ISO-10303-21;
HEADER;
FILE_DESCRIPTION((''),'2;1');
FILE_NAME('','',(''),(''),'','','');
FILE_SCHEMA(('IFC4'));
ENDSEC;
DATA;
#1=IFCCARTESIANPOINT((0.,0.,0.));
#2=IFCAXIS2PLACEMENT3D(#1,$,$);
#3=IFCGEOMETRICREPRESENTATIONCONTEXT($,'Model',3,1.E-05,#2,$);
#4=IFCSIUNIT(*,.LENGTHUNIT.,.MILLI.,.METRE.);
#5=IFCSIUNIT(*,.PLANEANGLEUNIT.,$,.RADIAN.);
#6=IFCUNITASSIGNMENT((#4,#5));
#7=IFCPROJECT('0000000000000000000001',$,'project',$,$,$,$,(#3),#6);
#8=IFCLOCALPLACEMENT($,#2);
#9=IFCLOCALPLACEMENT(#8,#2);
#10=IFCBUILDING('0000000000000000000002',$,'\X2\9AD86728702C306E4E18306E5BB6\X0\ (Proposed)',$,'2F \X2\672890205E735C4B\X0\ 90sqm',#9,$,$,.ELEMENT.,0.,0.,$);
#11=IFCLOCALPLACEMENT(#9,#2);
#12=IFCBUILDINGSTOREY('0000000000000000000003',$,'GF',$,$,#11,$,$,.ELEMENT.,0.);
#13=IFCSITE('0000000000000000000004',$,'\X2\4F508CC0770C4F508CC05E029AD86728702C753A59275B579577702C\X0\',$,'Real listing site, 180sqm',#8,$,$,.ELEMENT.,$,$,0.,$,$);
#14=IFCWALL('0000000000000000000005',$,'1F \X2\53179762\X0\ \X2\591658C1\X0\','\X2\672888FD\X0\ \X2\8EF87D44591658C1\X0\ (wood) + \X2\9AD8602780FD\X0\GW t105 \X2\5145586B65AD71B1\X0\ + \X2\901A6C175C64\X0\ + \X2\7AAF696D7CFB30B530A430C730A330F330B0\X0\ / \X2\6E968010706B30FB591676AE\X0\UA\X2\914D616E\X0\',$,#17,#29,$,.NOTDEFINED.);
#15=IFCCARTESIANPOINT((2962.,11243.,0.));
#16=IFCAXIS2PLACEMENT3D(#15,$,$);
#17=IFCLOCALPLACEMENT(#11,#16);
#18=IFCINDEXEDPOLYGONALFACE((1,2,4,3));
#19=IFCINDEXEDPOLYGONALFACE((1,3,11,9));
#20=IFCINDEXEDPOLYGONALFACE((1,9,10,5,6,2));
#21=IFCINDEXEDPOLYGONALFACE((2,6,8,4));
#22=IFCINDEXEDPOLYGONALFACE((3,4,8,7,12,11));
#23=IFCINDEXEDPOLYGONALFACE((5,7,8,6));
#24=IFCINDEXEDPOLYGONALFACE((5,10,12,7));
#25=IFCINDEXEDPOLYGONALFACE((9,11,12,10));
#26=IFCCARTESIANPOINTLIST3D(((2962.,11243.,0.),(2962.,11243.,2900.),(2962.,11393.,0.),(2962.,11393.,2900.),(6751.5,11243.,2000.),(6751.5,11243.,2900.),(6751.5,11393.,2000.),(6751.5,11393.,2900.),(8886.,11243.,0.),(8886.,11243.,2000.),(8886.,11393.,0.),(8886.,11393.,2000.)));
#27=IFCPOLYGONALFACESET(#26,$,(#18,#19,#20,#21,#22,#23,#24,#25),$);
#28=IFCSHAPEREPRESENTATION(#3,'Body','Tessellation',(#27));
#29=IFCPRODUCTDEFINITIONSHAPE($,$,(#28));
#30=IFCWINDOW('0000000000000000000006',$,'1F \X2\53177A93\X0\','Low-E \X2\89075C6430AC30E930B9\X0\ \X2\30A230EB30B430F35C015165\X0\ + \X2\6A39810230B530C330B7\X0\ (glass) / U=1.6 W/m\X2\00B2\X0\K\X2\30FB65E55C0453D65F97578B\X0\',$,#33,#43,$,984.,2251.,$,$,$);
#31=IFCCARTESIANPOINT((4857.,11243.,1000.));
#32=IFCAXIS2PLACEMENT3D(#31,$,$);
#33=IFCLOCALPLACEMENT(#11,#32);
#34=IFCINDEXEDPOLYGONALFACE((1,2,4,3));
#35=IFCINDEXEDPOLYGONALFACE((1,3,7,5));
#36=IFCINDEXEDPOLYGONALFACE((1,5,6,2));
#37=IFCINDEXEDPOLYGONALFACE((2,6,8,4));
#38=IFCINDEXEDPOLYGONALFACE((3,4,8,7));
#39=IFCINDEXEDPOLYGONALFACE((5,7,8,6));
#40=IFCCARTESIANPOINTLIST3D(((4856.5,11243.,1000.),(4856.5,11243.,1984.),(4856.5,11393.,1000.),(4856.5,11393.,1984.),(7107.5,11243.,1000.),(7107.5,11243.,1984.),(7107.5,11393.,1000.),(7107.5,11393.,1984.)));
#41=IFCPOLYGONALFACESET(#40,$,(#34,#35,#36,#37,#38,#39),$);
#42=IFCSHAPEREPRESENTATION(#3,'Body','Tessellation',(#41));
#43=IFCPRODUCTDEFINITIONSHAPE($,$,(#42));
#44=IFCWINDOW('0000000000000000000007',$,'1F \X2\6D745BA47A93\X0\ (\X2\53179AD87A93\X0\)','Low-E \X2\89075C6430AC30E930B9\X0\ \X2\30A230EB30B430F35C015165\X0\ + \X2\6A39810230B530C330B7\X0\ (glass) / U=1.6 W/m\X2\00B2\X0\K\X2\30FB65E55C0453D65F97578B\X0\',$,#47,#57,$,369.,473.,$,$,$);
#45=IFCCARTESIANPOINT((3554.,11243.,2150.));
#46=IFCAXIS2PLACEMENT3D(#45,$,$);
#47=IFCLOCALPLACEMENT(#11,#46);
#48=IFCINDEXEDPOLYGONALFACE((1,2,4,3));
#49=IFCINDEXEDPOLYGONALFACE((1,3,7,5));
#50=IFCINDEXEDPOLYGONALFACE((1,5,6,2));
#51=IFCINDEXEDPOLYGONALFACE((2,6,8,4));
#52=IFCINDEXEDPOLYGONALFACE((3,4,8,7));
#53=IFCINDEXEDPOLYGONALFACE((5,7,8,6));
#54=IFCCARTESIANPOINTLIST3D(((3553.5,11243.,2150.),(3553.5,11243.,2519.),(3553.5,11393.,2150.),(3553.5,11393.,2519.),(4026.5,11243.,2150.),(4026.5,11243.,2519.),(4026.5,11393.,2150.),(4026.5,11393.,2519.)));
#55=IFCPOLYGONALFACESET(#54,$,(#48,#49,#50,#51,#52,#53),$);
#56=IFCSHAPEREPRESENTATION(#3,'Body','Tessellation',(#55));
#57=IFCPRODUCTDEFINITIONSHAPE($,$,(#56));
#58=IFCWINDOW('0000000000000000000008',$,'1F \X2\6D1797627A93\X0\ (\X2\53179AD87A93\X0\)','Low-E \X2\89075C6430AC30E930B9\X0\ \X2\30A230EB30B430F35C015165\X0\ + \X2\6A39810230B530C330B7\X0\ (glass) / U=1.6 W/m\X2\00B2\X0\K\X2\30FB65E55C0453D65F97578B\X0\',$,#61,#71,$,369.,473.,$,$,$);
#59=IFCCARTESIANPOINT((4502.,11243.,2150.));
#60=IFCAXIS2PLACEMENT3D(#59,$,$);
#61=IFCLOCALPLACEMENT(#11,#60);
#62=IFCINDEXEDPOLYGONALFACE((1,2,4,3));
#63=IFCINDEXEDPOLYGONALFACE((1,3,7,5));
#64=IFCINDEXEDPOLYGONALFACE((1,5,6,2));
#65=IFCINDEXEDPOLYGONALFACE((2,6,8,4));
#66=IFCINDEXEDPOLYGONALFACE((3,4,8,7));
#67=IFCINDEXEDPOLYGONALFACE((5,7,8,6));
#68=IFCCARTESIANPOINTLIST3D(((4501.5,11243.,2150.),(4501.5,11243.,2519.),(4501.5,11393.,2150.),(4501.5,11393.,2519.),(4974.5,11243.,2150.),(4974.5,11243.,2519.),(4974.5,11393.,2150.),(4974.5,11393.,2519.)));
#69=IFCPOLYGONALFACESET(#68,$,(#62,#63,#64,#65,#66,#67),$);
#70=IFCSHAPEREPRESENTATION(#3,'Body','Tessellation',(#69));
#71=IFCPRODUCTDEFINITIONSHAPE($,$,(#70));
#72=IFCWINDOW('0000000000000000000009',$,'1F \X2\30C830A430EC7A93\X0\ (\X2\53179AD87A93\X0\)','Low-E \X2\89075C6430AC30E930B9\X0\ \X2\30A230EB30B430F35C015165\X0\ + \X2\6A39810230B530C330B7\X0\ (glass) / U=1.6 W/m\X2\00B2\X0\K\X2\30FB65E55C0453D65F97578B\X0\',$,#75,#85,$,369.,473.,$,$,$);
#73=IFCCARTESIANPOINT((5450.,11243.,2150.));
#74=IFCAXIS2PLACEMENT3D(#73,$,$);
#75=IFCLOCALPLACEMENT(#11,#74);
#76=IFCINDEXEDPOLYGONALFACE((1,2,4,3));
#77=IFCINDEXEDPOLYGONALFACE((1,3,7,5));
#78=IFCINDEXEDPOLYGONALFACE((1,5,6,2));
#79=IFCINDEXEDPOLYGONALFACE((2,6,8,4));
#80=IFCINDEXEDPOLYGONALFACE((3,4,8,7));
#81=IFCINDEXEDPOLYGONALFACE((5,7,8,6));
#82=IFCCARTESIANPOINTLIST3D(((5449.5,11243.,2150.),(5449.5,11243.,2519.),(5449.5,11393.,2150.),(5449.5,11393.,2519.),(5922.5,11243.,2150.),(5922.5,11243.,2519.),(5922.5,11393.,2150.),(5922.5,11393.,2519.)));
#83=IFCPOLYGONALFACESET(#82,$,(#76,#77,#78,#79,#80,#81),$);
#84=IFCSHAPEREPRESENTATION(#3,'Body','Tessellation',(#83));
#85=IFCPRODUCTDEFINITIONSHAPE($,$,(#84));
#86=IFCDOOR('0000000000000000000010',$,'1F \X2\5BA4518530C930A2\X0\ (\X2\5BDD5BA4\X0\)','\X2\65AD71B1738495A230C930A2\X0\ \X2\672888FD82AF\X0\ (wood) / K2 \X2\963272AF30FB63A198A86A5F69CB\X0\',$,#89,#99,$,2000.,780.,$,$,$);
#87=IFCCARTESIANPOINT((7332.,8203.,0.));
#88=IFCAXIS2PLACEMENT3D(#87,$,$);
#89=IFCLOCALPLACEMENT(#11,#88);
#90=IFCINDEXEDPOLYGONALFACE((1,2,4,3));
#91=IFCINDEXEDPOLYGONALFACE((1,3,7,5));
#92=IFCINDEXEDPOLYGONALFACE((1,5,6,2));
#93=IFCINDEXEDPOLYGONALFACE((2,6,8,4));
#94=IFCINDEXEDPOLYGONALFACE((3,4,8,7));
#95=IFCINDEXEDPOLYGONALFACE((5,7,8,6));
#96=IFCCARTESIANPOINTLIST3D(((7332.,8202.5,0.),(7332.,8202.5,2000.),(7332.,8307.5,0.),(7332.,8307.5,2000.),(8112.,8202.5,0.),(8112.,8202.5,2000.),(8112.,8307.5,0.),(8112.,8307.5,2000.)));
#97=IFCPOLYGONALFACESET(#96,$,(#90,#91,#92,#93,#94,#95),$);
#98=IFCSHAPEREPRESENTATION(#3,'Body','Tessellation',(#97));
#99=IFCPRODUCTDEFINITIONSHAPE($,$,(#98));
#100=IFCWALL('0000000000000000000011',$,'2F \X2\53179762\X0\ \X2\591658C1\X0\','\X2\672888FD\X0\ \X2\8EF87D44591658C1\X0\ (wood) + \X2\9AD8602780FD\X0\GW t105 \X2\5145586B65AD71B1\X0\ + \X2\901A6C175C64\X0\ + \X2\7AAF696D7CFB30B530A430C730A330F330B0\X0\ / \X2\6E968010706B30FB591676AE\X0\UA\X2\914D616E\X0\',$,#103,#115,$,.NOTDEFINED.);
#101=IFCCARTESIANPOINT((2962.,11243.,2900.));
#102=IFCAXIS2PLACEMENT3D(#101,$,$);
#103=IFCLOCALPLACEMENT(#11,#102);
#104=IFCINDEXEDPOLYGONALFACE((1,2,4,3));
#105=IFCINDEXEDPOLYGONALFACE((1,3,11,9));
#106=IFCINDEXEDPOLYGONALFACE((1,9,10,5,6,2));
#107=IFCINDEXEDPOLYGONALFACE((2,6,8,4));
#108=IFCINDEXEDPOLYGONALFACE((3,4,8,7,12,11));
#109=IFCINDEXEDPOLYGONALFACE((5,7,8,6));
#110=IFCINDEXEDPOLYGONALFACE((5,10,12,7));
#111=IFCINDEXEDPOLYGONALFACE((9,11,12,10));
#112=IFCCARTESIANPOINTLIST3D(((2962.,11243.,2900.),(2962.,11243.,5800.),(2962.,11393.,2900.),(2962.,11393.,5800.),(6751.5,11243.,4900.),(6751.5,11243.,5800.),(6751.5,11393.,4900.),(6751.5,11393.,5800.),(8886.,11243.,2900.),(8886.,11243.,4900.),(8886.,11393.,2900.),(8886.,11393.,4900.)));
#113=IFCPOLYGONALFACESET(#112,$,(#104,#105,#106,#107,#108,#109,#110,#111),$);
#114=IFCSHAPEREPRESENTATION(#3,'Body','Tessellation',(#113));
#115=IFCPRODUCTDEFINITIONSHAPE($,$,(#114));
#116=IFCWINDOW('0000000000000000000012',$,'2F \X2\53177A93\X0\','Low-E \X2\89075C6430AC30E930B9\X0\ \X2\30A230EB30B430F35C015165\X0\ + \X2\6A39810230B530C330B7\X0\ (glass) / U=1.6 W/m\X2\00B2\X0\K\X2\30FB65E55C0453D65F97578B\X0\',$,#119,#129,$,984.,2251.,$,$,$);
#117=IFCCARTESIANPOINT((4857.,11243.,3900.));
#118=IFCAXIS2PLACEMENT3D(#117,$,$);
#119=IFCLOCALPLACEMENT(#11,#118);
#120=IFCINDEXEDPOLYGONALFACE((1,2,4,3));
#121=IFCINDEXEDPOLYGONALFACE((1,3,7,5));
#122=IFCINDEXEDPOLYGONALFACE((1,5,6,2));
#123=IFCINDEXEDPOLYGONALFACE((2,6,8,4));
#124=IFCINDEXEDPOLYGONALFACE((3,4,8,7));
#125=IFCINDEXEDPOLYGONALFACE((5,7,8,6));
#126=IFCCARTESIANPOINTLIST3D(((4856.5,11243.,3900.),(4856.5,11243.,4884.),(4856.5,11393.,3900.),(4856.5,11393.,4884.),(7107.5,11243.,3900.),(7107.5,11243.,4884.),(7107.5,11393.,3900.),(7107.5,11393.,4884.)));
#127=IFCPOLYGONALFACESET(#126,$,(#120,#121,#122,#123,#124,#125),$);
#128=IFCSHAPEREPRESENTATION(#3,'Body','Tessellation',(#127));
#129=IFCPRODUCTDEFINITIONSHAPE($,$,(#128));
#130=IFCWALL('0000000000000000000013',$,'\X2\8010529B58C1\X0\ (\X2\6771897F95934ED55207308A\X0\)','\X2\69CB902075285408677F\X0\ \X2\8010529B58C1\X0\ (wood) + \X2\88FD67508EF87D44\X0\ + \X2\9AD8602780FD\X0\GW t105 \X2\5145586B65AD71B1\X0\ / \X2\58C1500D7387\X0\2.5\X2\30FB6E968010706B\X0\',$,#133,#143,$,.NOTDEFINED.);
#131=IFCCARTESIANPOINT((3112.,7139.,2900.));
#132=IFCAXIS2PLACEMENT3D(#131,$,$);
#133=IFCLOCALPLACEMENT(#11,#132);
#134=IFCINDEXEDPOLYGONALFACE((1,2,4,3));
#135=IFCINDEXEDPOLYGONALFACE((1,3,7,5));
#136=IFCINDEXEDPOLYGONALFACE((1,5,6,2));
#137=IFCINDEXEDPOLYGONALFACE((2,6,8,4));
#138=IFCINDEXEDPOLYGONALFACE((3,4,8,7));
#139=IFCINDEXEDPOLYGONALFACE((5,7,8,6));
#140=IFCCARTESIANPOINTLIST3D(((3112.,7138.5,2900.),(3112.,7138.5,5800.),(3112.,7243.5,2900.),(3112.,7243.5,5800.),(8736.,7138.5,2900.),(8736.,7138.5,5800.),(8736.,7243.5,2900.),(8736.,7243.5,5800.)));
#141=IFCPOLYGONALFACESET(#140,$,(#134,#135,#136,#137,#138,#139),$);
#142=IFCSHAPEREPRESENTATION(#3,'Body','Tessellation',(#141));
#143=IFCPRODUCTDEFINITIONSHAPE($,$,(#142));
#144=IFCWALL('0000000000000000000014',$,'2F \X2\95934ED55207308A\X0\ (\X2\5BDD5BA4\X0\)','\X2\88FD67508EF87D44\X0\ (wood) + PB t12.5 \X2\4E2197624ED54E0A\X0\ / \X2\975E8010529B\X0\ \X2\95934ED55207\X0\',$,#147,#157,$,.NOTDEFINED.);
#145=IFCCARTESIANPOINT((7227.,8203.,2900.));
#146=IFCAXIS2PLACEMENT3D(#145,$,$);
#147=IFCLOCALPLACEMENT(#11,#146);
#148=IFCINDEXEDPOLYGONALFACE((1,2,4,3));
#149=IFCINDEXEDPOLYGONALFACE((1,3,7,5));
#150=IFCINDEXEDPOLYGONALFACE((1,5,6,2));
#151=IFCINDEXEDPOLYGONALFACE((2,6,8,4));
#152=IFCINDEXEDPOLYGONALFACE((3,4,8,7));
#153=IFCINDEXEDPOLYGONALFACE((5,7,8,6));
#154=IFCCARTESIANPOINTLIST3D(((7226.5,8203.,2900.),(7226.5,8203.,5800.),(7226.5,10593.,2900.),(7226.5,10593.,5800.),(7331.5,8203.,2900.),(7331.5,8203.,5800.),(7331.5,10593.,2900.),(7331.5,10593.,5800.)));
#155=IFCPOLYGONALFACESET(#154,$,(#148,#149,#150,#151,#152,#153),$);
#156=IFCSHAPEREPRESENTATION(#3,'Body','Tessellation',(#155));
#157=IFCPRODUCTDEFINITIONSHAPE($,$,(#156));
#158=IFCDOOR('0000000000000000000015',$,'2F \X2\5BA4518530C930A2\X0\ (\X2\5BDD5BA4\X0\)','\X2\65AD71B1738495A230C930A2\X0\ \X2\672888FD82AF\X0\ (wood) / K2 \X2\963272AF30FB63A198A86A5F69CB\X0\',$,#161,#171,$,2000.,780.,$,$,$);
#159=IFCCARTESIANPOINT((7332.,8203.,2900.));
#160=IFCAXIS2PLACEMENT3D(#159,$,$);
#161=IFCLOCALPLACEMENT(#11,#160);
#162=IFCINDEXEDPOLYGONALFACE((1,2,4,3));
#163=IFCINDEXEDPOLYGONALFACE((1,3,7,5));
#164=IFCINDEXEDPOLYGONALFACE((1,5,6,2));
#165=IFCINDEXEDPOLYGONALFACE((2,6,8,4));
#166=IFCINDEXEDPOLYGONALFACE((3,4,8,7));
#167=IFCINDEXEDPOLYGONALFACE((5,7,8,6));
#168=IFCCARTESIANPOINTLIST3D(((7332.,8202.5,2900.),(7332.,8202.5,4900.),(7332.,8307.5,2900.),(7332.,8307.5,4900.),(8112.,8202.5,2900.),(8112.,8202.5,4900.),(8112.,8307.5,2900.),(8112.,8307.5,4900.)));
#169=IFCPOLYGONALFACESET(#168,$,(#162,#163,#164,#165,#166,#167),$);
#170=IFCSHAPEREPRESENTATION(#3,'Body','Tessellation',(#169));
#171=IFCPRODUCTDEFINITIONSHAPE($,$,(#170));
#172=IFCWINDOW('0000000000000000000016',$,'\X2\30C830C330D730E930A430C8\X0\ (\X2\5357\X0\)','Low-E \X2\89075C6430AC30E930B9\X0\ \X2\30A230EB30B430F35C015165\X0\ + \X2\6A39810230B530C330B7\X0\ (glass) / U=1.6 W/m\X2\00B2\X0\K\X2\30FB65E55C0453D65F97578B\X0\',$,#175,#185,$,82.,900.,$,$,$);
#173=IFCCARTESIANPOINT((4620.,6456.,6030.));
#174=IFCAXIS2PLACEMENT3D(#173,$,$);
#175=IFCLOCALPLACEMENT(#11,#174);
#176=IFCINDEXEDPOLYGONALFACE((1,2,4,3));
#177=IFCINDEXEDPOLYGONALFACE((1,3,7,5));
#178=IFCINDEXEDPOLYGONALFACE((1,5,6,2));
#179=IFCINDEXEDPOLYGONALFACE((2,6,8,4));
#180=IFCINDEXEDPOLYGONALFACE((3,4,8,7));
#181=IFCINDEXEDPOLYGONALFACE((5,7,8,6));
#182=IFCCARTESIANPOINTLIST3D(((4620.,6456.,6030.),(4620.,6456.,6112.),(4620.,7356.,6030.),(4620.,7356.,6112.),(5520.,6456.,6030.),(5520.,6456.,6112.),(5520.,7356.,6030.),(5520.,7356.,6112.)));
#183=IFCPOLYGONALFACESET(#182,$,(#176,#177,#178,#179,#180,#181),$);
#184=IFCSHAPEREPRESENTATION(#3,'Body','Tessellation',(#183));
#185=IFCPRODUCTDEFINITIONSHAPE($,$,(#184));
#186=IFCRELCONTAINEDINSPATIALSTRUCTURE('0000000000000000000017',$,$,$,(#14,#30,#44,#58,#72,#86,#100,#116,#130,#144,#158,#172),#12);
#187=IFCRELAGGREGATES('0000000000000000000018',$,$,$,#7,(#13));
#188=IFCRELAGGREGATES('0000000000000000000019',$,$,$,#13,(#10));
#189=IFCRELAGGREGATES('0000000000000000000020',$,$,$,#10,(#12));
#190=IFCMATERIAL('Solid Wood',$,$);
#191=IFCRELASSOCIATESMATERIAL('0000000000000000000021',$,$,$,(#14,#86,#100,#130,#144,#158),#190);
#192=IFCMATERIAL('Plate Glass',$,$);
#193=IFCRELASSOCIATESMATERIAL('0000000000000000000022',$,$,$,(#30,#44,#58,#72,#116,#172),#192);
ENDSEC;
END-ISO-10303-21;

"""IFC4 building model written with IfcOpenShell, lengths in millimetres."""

from ifc_helpers import new_model, si_unit, frame, frame_2d, origin, place, context, project, spatial, rectangle, extrude, material, element, fill, save


model = new_model("IFC4")

# Units and contexts
model_context = context("Model", 3, precision=1e-05, world=origin())
ifc_project = project(units=[si_unit("LENGTHUNIT", "METRE", prefix="MILLI"), si_unit("PLANEANGLEUNIT", "RADIAN")], contexts=[model_context])

# Site, building, storey
site_placement = place(None, origin())
site = spatial("IfcSite", under=ifc_project, at=site_placement, Name="佐賀県佐賀市高木瀬町大字長瀬", ObjectType="Real listing site, 180sqm", CompositionType="ELEMENT", RefElevation=0.0)
building_placement = place(site_placement, origin())
building = spatial("IfcBuilding", under=site, at=building_placement, Name="高木瀬の丘の家 (Proposed)", ObjectType="2F 木造平屋 90sqm", CompositionType="ELEMENT", ElevationOfRefHeight=0.0, ElevationOfTerrain=0.0)
storey_placement = place(building_placement, origin())
storey = spatial("IfcBuildingStorey", under=building, at=storey_placement, Name="GF", CompositionType="ELEMENT", Elevation=0.0)

# Wall, openings, windows
ifc_material_1 = material(Name="Solid Wood")
wall_1_placement = place(storey_placement, frame((2962.0, 11243.0, 0.0)))
wall_1 = element("IfcWall", 1, at=wall_1_placement, inside=storey, material=ifc_material_1, Name="1F 北面 外壁", Description="木製 軸組外壁 (wood) + 高性能GW t105 充填断熱 + 通気層 + 窯業系サイディング / 準耐火・外皮UA配慮", PredefinedType="NOTDEFINED", context=model_context, shape_type="SweptSolid", body=[
    extrude(rectangle(XDim=5924.0, YDim=150.0, at=frame_2d((2962.0, 75.0))), frame((2962.0, 11243.0, 0.0)), (0.0, 0.0, 1.0), 2900.0),
])
opening_1_placement = place(storey_placement, frame((4857.0, 11243.0, 1000.0)))
opening_1 = element("IfcOpeningElement", 2, at=opening_1_placement, cuts=wall_1, PredefinedType="NOTDEFINED", context=model_context, shape_type="SweptSolid", body=[
    extrude(rectangle(XDim=2251.0, YDim=150.0, at=frame_2d((1125.0, 75.0))), frame((4857.0, 11243.0, 1000.0)), (0.0, 0.0, 1.0), 984.0),
])
opening_2_placement = place(storey_placement, frame((3554.0, 11243.0, 2150.0)))
opening_2 = element("IfcOpeningElement", 3, at=opening_2_placement, cuts=wall_1, PredefinedType="NOTDEFINED", context=model_context, shape_type="SweptSolid", body=[
    extrude(rectangle(XDim=473.0, YDim=150.0, at=frame_2d((236.0, 75.0))), frame((3554.0, 11243.0, 2150.0)), (0.0, 0.0, 1.0), 369.0),
])
opening_3_placement = place(storey_placement, frame((4502.0, 11243.0, 2150.0)))
opening_3 = element("IfcOpeningElement", 4, at=opening_3_placement, cuts=wall_1, PredefinedType="NOTDEFINED", context=model_context, shape_type="SweptSolid", body=[
    extrude(rectangle(XDim=473.0, YDim=150.0, at=frame_2d((236.0, 75.0))), frame((4502.0, 11243.0, 2150.0)), (0.0, 0.0, 1.0), 369.0),
])
opening_4_placement = place(storey_placement, frame((5450.0, 11243.0, 2150.0)))
opening_4 = element("IfcOpeningElement", 5, at=opening_4_placement, cuts=wall_1, PredefinedType="NOTDEFINED", context=model_context, shape_type="SweptSolid", body=[
    extrude(rectangle(XDim=473.0, YDim=150.0, at=frame_2d((236.0, 75.0))), frame((5450.0, 11243.0, 2150.0)), (0.0, 0.0, 1.0), 369.0),
])
ifc_material_2 = material(Name="Plate Glass")
window_1_placement = place(storey_placement, frame((4857.0, 11243.0, 1000.0)))
window_1 = element("IfcWindow", 6, at=window_1_placement, inside=storey, material=ifc_material_2, Name="1F 北窓", Description="Low-E 複層ガラス アルゴン封入 + 樹脂サッシ (glass) / U=1.6 W/m²K・日射取得型", OverallHeight=984.0, OverallWidth=2251.0, context=model_context, shape_type="SweptSolid", body=[
    extrude(rectangle(XDim=2251.0, YDim=150.0, at=frame_2d((1125.0, 75.0))), frame((4857.0, 11243.0, 1000.0)), (0.0, 0.0, 1.0), 984.0),
])
fill(opening_1, window_1)
window_2_placement = place(storey_placement, frame((3554.0, 11243.0, 2150.0)))
window_2 = element("IfcWindow", 7, at=window_2_placement, inside=storey, material=ifc_material_2, Name="1F 浴室窓 (北高窓)", Description="Low-E 複層ガラス アルゴン封入 + 樹脂サッシ (glass) / U=1.6 W/m²K・日射取得型", OverallHeight=369.0, OverallWidth=473.0, context=model_context, shape_type="SweptSolid", body=[
    extrude(rectangle(XDim=473.0, YDim=150.0, at=frame_2d((236.0, 75.0))), frame((3554.0, 11243.0, 2150.0)), (0.0, 0.0, 1.0), 369.0),
])
fill(opening_2, window_2)
window_3_placement = place(storey_placement, frame((4502.0, 11243.0, 2150.0)))
window_3 = element("IfcWindow", 8, at=window_3_placement, inside=storey, material=ifc_material_2, Name="1F 洗面窓 (北高窓)", Description="Low-E 複層ガラス アルゴン封入 + 樹脂サッシ (glass) / U=1.6 W/m²K・日射取得型", OverallHeight=369.0, OverallWidth=473.0, context=model_context, shape_type="SweptSolid", body=[
    extrude(rectangle(XDim=473.0, YDim=150.0, at=frame_2d((236.0, 75.0))), frame((4502.0, 11243.0, 2150.0)), (0.0, 0.0, 1.0), 369.0),
])
fill(opening_3, window_3)
window_4_placement = place(storey_placement, frame((5450.0, 11243.0, 2150.0)))
window_4 = element("IfcWindow", 9, at=window_4_placement, inside=storey, material=ifc_material_2, Name="1F トイレ窓 (北高窓)", Description="Low-E 複層ガラス アルゴン封入 + 樹脂サッシ (glass) / U=1.6 W/m²K・日射取得型", OverallHeight=369.0, OverallWidth=473.0, context=model_context, shape_type="SweptSolid", body=[
    extrude(rectangle(XDim=473.0, YDim=150.0, at=frame_2d((236.0, 75.0))), frame((5450.0, 11243.0, 2150.0)), (0.0, 0.0, 1.0), 369.0),
])
fill(opening_4, window_4)

# Door
door_1_placement = place(storey_placement, frame((7332.0, 8203.0, 0.0)))
element("IfcDoor", 10, at=door_1_placement, inside=storey, material=ifc_material_1, Name="1F 室内ドア (寝室)", Description="断熱玄関ドア 木製芯 (wood) / K2 防犯・採風機構", OverallHeight=2000.0, OverallWidth=780.0, context=model_context, shape_type="SweptSolid", body=[
    extrude(rectangle(XDim=780.0, YDim=105.0, at=frame_2d((390.0, 52.0))), frame((7332.0, 8203.0, 0.0)), (0.0, 0.0, 1.0), 2000.0),
])

# Wall, opening, window
wall_2_placement = place(storey_placement, frame((2962.0, 11243.0, 2900.0)))
wall_2 = element("IfcWall", 11, at=wall_2_placement, inside=storey, material=ifc_material_1, Name="2F 北面 外壁", Description="木製 軸組外壁 (wood) + 高性能GW t105 充填断熱 + 通気層 + 窯業系サイディング / 準耐火・外皮UA配慮", PredefinedType="NOTDEFINED", context=model_context, shape_type="SweptSolid", body=[
    extrude(rectangle(XDim=5924.0, YDim=150.0, at=frame_2d((2962.0, 75.0))), frame((2962.0, 11243.0, 2900.0)), (0.0, 0.0, 1.0), 2900.0),
])
opening_5_placement = place(storey_placement, frame((4857.0, 11243.0, 3900.0)))
opening_5 = element("IfcOpeningElement", 12, at=opening_5_placement, cuts=wall_2, PredefinedType="NOTDEFINED", context=model_context, shape_type="SweptSolid", body=[
    extrude(rectangle(XDim=2251.0, YDim=150.0, at=frame_2d((1125.0, 75.0))), frame((4857.0, 11243.0, 3900.0)), (0.0, 0.0, 1.0), 984.0),
])
window_5_placement = place(storey_placement, frame((4857.0, 11243.0, 3900.0)))
window_5 = element("IfcWindow", 13, at=window_5_placement, inside=storey, material=ifc_material_2, Name="2F 北窓", Description="Low-E 複層ガラス アルゴン封入 + 樹脂サッシ (glass) / U=1.6 W/m²K・日射取得型", OverallHeight=984.0, OverallWidth=2251.0, context=model_context, shape_type="SweptSolid", body=[
    extrude(rectangle(XDim=2251.0, YDim=150.0, at=frame_2d((1125.0, 75.0))), frame((4857.0, 11243.0, 3900.0)), (0.0, 0.0, 1.0), 984.0),
])
fill(opening_5, window_5)

# Walls
wall_3_placement = place(storey_placement, frame((3112.0, 7139.0, 2900.0)))
element("IfcWall", 14, at=wall_3_placement, inside=storey, material=ifc_material_1, Name="耐力壁 (東西間仕切り)", Description="構造用合板 耐力壁 (wood) + 製材軸組 + 高性能GW t105 充填断熱 / 壁倍率2.5・準耐火", PredefinedType="NOTDEFINED", context=model_context, shape_type="SweptSolid", body=[
    extrude(rectangle(XDim=5624.0, YDim=105.0, at=frame_2d((2812.0, 52.0))), frame((3112.0, 7139.0, 2900.0)), (0.0, 0.0, 1.0), 2900.0),
])
wall_4_placement = place(storey_placement, frame((7227.0, 8203.0, 2900.0)))
element("IfcWall", 15, at=wall_4_placement, inside=storey, material=ifc_material_1, Name="2F 間仕切り (寝室)", Description="製材軸組 (wood) + PB t12.5 両面仕上 / 非耐力 間仕切", PredefinedType="NOTDEFINED", context=model_context, shape_type="SweptSolid", body=[
    extrude(rectangle(XDim=105.0, YDim=2390.0, at=frame_2d((52.0, 1195.0))), frame((7227.0, 8203.0, 2900.0)), (0.0, 0.0, 1.0), 2900.0),
])

# Door
door_2_placement = place(storey_placement, frame((7332.0, 8203.0, 2900.0)))
element("IfcDoor", 16, at=door_2_placement, inside=storey, material=ifc_material_1, Name="2F 室内ドア (寝室)", Description="断熱玄関ドア 木製芯 (wood) / K2 防犯・採風機構", OverallHeight=2000.0, OverallWidth=780.0, context=model_context, shape_type="SweptSolid", body=[
    extrude(rectangle(XDim=780.0, YDim=105.0, at=frame_2d((390.0, 52.0))), frame((7332.0, 8203.0, 2900.0)), (0.0, 0.0, 1.0), 2000.0),
])

# Window
window_6_placement = place(storey_placement, frame((4620.0, 6456.0, 6030.0)))
element("IfcWindow", 17, at=window_6_placement, inside=storey, material=ifc_material_2, Name="トップライト (南)", Description="Low-E 複層ガラス アルゴン封入 + 樹脂サッシ (glass) / U=1.6 W/m²K・日射取得型", OverallHeight=82.0, OverallWidth=900.0, context=model_context, shape_type="SweptSolid", body=[
    extrude(rectangle(XDim=900.0, YDim=900.0, at=frame_2d((450.0, 450.0))), frame((4620.0, 6456.0, 6030.0)), (0.0, 0.0, 1.0), 82.0),
])

save(model, "model.ifc")
